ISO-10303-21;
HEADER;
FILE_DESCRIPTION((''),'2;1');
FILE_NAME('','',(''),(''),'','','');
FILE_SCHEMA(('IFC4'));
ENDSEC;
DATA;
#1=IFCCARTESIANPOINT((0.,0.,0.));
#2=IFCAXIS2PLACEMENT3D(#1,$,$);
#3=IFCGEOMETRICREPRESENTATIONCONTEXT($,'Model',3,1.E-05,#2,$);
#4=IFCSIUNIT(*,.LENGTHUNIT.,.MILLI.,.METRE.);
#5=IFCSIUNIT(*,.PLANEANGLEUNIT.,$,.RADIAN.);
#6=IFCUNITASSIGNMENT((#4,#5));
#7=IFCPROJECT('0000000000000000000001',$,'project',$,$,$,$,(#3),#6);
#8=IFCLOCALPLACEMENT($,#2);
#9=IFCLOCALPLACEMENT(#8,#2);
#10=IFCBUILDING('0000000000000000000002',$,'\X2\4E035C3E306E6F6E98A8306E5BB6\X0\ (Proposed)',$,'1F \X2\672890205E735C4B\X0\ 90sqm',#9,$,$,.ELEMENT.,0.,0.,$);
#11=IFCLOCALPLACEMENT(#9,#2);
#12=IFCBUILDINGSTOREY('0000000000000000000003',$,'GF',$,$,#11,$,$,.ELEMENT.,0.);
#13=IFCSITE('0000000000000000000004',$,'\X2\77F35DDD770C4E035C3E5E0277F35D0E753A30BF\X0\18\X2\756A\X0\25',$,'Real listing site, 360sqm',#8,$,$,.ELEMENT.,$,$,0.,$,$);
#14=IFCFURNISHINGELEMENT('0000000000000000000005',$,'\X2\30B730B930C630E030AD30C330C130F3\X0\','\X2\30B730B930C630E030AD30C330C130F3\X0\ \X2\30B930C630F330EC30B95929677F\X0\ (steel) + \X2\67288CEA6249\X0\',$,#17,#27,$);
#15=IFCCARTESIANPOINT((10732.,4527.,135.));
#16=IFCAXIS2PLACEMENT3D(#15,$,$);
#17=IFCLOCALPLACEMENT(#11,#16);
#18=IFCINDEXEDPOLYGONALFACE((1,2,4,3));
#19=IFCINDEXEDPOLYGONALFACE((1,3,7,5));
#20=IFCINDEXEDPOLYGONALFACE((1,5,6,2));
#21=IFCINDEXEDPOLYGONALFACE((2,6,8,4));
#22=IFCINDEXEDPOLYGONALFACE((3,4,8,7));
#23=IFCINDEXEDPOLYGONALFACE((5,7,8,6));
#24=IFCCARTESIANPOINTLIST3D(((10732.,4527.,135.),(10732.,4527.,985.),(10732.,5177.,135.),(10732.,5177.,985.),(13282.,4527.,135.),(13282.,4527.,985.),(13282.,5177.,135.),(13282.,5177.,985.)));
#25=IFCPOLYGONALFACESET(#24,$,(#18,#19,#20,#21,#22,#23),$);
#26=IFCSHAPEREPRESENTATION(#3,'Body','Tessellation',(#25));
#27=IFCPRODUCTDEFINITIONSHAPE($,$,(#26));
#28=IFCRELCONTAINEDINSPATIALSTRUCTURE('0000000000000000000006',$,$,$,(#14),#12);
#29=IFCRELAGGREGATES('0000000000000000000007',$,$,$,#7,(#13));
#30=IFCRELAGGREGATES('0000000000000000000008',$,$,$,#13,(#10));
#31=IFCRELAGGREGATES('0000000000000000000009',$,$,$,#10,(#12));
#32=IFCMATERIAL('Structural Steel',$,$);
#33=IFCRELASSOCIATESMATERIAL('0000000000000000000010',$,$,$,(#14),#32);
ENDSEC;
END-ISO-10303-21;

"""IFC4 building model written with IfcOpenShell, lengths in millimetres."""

from ifc_helpers import new_model, si_unit, frame, frame_2d, origin, place, context, project, spatial, rectangle, extrude, material, element, save


model = new_model("IFC4")

# Units and contexts
model_context = context("Model", 3, precision=1e-05, world=origin())
ifc_project = project(units=[si_unit("LENGTHUNIT", "METRE", prefix="MILLI"), si_unit("PLANEANGLEUNIT", "RADIAN")], contexts=[model_context])

# Site, building, storey
site_placement = place(None, origin())
site = spatial("IfcSite", under=ifc_project, at=site_placement, Name="石川県七尾市石崎町タ18番25", ObjectType="Real listing site, 360sqm", CompositionType="ELEMENT", RefElevation=0.0)
building_placement = place(site_placement, origin())
building = spatial("IfcBuilding", under=site, at=building_placement, Name="七尾の潮風の家 (Proposed)", ObjectType="1F 木造平屋 90sqm", CompositionType="ELEMENT", ElevationOfRefHeight=0.0, ElevationOfTerrain=0.0)
storey_placement = place(building_placement, origin())
storey = spatial("IfcBuildingStorey", under=building, at=storey_placement, Name="GF", CompositionType="ELEMENT", Elevation=0.0)

# Shared definitions
ifc_material_1 = material(Name="Structural Steel")

# Furnishing element
furnishing_1_placement = place(storey_placement, frame((10732.0, 4527.0, 135.0)))
element("IfcFurnishingElement", 1, at=furnishing_1_placement, inside=storey, material=ifc_material_1, Name="システムキッチン", Description="システムキッチン ステンレス天板 (steel) + 木質扉", context=model_context, shape_type="SweptSolid", body=[
    extrude(rectangle(XDim=2550.0, YDim=650.0, at=frame_2d((1275.0, 325.0))), frame((10732.0, 4527.0, 135.0)), (0.0, 0.0, 1.0), 850.0),
])

save(model, "model.ifc")
